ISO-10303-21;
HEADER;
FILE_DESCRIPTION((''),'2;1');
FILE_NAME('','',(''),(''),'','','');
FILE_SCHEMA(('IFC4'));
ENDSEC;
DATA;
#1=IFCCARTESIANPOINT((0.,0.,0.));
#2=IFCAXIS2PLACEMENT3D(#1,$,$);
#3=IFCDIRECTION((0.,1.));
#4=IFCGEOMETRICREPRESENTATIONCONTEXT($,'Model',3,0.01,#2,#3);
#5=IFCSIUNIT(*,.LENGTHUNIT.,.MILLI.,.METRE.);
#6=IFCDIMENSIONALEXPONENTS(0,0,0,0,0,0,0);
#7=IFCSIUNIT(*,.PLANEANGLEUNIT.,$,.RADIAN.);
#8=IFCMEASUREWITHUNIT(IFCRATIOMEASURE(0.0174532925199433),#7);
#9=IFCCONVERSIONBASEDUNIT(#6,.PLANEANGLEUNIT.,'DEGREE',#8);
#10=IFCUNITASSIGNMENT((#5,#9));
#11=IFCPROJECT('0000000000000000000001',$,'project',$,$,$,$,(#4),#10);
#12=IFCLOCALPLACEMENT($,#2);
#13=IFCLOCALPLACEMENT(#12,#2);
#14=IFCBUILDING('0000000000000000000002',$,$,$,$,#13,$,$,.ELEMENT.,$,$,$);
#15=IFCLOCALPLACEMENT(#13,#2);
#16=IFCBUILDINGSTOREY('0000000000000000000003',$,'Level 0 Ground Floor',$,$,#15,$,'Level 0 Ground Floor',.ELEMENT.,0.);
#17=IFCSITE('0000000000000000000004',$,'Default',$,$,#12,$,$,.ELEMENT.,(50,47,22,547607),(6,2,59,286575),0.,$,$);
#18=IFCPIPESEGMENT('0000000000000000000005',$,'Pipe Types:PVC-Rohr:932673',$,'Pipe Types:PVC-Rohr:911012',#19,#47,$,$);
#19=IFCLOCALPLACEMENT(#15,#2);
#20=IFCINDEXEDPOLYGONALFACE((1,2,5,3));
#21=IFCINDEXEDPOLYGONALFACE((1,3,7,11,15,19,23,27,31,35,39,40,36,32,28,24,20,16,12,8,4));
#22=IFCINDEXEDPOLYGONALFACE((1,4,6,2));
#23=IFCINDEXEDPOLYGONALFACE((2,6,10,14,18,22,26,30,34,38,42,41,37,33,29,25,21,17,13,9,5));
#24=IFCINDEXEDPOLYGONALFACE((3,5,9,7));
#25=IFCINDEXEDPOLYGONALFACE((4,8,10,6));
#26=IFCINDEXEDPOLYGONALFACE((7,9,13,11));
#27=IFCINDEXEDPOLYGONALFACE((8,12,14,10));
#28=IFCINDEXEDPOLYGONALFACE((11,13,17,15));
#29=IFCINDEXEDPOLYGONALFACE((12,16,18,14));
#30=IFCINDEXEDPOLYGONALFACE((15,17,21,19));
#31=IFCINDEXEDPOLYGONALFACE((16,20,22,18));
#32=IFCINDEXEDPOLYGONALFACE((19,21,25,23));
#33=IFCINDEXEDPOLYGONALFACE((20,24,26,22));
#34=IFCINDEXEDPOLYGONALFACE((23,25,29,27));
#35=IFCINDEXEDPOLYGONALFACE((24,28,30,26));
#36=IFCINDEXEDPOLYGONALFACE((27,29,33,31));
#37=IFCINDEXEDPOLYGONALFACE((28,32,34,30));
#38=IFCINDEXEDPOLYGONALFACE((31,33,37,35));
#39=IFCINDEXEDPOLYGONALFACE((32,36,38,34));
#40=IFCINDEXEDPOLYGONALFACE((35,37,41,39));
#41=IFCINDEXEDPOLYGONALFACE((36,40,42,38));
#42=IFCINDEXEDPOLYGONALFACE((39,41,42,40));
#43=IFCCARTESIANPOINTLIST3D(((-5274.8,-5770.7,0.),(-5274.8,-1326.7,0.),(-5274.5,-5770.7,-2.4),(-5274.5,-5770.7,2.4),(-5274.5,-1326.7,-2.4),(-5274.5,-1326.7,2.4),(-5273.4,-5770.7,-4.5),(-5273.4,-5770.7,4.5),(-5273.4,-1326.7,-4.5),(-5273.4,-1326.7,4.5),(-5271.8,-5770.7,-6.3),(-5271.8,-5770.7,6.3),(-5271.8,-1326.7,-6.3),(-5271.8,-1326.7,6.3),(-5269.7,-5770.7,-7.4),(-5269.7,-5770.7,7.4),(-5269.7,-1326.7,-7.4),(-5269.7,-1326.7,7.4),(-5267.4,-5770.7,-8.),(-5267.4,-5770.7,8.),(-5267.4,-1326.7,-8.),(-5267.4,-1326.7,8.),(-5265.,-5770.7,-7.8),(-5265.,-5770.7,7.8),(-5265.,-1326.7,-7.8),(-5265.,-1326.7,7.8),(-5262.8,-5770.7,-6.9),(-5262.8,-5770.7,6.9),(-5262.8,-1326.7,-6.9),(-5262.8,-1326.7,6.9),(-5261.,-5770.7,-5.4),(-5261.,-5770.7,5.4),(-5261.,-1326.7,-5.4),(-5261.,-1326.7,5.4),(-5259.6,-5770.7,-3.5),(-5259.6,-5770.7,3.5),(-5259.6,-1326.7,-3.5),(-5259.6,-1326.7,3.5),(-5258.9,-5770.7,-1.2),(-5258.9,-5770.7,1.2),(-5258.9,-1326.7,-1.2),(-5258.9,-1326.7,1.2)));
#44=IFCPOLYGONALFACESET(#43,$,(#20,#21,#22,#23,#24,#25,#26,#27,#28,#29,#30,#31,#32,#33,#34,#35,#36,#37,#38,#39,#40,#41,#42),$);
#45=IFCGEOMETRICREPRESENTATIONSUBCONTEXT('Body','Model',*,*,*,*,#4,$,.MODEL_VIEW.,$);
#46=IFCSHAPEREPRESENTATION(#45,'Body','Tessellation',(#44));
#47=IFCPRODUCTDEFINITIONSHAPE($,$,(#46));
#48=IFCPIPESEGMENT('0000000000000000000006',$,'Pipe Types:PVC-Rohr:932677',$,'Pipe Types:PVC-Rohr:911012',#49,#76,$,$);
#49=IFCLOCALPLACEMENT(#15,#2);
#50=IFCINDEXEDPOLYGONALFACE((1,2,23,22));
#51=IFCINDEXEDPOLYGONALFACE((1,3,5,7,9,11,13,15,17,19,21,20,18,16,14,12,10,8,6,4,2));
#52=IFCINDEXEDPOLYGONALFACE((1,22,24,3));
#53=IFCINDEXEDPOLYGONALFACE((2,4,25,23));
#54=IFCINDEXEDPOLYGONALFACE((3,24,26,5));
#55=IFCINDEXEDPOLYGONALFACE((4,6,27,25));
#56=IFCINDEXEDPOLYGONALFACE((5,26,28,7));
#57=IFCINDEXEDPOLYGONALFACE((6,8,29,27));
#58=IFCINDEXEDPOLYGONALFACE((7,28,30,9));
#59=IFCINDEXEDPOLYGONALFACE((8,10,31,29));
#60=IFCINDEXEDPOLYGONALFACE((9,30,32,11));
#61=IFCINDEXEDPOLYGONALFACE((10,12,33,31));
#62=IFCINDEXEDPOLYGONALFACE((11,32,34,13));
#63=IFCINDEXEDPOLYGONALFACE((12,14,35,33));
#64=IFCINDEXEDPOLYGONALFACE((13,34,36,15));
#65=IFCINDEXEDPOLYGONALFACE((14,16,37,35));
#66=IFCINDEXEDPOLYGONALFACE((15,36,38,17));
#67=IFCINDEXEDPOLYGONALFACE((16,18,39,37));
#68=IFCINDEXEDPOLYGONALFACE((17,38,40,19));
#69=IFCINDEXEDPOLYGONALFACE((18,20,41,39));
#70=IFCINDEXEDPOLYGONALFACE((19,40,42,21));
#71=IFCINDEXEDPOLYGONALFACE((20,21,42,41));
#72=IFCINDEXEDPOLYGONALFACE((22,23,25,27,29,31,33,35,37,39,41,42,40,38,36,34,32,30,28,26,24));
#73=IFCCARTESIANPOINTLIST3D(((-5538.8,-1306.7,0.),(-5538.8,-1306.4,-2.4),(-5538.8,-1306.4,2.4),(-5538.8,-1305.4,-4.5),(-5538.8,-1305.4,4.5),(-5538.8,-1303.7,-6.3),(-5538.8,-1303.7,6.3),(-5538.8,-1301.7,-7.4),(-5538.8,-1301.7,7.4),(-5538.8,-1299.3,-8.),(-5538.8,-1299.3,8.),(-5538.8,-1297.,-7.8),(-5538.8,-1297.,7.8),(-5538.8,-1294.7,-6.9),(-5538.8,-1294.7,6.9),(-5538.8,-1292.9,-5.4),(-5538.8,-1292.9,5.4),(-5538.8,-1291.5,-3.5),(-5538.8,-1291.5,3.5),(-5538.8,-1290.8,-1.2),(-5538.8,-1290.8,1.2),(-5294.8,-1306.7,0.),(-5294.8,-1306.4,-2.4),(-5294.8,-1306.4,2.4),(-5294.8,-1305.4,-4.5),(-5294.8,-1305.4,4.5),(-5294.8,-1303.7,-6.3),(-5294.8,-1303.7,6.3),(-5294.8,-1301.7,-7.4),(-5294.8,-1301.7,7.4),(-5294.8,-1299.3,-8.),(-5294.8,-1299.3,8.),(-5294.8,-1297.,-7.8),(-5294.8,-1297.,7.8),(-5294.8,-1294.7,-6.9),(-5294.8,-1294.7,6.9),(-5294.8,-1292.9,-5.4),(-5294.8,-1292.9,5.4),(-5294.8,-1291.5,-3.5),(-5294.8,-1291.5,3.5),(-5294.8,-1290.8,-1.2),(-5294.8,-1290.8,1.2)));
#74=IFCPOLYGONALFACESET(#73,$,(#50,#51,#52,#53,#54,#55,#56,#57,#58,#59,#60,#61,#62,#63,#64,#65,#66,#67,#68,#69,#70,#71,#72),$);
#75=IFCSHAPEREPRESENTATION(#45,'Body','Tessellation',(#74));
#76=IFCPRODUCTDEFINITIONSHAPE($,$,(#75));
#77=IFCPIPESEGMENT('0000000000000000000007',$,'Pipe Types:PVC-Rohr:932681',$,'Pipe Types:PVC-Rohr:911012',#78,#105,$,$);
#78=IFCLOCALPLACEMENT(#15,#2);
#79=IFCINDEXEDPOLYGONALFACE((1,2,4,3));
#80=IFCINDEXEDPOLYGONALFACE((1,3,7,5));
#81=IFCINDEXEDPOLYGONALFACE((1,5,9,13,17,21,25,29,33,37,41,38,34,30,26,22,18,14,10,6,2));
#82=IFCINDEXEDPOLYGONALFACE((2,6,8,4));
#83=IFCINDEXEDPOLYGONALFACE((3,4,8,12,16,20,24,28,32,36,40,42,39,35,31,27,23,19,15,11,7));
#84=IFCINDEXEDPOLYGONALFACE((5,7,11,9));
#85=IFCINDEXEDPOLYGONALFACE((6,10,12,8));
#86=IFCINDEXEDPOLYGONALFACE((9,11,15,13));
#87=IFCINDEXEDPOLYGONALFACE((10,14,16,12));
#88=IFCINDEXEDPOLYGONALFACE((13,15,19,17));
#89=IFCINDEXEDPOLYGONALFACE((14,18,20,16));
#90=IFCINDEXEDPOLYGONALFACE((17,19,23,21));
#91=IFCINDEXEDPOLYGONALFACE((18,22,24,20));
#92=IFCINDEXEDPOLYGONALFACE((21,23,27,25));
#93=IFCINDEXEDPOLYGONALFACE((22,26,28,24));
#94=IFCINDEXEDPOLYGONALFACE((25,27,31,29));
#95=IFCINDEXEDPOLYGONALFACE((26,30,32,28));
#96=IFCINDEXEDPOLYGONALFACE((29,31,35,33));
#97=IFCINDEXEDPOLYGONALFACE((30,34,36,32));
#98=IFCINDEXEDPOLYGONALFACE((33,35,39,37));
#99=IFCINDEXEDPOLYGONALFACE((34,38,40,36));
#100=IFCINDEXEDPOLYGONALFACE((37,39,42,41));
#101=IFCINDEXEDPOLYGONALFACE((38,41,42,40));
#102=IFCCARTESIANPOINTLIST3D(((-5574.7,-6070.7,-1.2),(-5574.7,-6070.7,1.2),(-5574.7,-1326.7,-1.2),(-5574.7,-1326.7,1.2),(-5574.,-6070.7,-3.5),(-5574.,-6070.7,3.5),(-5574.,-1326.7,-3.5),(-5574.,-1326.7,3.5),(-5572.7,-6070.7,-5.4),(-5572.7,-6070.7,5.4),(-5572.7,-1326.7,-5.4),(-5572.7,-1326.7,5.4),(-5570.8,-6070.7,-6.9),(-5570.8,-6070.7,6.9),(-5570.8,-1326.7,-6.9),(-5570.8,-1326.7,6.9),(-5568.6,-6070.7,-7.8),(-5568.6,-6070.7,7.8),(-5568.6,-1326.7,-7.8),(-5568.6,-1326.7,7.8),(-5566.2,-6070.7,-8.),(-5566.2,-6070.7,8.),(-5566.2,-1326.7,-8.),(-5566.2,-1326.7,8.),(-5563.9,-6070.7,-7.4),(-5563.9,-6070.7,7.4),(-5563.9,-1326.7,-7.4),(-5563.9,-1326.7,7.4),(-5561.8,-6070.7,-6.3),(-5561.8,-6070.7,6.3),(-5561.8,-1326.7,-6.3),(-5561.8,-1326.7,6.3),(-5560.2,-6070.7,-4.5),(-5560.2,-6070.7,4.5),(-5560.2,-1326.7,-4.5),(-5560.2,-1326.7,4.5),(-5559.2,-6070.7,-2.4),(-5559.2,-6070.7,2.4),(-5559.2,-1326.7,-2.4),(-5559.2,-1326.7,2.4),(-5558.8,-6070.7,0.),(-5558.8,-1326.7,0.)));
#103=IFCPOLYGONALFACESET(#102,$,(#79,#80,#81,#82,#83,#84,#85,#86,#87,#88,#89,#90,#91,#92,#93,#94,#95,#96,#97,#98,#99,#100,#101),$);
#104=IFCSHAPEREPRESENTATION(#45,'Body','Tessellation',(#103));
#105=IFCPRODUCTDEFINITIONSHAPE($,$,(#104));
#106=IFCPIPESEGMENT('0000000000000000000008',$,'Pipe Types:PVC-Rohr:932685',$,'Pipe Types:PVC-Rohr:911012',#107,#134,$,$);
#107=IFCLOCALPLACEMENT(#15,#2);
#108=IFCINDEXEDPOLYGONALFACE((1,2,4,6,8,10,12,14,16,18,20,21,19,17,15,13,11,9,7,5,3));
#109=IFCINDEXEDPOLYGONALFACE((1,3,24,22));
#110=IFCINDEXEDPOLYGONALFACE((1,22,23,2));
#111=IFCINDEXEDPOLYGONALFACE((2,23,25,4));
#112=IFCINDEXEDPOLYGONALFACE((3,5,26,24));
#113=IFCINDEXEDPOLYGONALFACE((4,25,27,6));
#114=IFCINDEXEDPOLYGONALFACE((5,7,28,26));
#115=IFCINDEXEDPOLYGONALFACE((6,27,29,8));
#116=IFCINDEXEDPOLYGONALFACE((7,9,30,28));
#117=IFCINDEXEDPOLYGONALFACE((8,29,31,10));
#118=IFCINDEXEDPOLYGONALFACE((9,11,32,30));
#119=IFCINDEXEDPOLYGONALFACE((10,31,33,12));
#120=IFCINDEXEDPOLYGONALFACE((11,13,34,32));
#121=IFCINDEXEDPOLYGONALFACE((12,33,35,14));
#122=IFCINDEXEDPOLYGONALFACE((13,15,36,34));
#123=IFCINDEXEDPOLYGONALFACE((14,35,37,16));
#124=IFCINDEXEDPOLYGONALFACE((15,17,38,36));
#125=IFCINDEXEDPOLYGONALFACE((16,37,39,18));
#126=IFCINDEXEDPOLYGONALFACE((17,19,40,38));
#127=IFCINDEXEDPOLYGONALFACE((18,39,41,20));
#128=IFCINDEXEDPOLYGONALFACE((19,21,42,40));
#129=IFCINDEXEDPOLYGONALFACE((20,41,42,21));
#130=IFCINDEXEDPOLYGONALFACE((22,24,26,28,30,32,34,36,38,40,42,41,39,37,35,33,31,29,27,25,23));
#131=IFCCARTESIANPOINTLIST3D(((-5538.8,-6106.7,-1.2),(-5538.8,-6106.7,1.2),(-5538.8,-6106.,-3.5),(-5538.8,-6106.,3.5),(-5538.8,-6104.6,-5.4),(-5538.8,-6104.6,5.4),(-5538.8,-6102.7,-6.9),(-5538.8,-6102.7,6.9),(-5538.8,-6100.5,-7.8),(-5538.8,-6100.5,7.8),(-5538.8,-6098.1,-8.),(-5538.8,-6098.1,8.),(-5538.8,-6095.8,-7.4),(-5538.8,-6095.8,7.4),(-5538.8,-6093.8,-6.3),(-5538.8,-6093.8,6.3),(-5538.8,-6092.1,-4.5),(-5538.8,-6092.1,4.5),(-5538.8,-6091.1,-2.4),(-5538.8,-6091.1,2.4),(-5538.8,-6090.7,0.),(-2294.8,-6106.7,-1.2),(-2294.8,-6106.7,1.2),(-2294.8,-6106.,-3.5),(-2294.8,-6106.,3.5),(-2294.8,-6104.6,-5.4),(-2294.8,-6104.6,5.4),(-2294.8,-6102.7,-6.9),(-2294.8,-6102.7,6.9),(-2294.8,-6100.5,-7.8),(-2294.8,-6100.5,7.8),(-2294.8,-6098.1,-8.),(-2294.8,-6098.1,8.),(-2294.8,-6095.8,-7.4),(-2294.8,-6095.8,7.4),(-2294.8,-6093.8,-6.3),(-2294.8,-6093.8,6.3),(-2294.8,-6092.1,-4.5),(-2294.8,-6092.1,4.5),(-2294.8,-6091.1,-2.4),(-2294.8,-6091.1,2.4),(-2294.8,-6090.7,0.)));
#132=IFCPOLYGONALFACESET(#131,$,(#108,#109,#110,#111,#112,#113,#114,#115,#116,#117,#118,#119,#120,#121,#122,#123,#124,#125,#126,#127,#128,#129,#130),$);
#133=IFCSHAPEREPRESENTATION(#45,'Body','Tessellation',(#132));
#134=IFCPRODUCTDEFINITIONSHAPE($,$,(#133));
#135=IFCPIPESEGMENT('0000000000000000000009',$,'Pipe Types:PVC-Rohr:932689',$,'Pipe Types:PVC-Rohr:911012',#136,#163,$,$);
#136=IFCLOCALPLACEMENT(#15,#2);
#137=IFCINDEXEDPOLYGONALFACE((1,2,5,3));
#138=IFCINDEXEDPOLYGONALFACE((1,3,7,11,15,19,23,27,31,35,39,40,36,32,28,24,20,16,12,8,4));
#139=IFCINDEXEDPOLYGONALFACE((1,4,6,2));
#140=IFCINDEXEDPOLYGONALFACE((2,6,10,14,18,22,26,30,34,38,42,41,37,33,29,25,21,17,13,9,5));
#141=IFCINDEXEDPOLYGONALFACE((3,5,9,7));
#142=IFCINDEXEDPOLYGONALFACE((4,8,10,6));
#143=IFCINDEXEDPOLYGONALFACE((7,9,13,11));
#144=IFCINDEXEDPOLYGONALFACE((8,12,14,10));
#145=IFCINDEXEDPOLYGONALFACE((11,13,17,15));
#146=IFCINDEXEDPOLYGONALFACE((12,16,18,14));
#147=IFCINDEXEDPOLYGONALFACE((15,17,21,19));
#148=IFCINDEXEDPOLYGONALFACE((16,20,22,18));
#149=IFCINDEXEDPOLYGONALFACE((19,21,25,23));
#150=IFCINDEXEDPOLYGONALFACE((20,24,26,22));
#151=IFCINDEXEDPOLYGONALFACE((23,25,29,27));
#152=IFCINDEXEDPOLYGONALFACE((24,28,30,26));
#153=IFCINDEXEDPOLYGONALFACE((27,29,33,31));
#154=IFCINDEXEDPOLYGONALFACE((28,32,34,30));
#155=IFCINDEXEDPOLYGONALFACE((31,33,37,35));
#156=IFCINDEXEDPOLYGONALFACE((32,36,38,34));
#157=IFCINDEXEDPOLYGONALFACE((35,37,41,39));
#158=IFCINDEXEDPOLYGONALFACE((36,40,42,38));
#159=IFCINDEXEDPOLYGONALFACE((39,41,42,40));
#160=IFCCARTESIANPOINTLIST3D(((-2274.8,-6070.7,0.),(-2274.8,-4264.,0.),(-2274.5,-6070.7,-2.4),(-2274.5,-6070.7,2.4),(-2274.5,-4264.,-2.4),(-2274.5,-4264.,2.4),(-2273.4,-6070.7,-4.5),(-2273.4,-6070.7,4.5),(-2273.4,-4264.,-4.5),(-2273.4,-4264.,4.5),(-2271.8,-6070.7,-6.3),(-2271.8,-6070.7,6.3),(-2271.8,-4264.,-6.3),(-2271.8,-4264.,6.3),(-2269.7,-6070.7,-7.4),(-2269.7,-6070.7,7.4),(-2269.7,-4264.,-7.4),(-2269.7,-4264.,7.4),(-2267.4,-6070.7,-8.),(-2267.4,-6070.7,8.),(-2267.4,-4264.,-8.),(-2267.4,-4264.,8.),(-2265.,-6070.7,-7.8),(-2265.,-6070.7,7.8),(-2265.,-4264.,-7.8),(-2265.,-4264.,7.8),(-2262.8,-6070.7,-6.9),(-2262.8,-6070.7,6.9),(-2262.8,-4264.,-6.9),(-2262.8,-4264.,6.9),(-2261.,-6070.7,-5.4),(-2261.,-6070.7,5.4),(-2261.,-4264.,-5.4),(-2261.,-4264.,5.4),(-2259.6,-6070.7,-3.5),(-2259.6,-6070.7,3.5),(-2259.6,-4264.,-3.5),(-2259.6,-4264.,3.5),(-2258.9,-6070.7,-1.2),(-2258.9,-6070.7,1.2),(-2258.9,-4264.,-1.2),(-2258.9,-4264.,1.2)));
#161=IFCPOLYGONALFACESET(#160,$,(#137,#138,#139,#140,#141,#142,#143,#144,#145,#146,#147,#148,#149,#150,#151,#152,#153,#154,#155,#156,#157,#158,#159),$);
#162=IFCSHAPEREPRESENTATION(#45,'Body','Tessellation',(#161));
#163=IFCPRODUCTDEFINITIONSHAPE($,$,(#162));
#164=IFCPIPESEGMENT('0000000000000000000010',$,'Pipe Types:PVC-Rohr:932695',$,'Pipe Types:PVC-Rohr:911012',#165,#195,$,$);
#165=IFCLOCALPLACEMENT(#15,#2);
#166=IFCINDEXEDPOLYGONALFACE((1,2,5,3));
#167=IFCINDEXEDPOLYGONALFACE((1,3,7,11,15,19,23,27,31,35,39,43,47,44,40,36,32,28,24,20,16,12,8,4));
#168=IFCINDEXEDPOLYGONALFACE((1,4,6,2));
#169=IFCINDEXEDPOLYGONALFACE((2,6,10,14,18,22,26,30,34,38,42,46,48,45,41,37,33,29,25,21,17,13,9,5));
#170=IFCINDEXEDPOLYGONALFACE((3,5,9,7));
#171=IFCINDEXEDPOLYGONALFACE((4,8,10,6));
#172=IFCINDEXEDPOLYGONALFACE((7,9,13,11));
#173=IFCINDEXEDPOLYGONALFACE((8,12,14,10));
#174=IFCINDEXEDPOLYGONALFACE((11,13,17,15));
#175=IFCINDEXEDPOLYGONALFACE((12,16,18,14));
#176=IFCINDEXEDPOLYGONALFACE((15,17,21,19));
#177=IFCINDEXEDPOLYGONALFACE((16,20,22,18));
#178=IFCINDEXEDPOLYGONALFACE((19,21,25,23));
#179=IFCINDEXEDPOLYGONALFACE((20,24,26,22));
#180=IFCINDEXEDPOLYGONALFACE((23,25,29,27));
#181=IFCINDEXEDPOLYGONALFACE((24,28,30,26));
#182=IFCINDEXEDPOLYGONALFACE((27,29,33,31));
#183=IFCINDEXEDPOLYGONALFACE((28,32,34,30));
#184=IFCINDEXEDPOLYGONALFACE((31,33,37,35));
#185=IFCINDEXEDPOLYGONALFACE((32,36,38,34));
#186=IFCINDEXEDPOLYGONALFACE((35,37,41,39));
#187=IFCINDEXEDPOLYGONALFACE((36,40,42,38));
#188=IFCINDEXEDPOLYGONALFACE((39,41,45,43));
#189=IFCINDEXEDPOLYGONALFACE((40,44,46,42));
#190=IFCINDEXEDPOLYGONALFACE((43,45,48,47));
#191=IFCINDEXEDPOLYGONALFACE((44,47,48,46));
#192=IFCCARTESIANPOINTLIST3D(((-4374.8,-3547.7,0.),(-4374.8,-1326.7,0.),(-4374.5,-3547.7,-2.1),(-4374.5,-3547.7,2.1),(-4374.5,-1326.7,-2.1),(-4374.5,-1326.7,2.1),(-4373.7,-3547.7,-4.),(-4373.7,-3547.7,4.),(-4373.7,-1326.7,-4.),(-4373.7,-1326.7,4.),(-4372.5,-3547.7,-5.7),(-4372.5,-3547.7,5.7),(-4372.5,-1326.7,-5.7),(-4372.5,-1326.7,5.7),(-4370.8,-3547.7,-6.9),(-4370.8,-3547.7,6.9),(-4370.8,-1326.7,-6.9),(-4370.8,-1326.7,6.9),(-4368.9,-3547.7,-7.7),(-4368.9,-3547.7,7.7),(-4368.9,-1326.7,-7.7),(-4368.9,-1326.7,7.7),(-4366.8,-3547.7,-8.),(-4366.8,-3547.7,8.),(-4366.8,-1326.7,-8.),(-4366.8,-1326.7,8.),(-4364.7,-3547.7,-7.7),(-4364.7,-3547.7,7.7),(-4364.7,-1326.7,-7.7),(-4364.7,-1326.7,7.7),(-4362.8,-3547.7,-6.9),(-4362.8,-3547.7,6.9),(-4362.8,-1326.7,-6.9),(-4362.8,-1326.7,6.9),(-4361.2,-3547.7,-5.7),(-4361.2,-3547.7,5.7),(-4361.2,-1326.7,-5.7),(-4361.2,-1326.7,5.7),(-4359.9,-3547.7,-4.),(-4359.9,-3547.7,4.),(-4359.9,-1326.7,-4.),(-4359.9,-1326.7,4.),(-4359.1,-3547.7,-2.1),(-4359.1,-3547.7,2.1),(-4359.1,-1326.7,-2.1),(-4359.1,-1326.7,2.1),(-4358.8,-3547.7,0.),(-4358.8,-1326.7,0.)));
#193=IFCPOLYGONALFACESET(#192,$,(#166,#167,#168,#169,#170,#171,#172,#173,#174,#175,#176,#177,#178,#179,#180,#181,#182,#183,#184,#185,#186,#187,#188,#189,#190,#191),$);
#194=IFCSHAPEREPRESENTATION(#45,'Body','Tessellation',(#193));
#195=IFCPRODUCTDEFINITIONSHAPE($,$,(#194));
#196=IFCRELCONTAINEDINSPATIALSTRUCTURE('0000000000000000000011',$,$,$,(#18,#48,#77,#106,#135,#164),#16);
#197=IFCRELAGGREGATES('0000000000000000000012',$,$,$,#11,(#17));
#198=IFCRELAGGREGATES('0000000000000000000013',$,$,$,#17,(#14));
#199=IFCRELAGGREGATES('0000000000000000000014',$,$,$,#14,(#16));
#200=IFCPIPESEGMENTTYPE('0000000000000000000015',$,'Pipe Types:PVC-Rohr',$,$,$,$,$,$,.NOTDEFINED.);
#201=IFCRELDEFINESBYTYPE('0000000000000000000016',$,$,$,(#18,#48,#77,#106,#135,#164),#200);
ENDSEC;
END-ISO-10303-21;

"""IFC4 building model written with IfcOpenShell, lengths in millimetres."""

from ifc_helpers import new_model, entity, si_unit, converted_unit, direction, frame, frame_2d, origin, place, context, subcontext, project, spatial, polyline, circle, outline, extrude, type_object, element, save


model = new_model("IFC4")

# Units and contexts
model_context = context("Model", 3, precision=0.01, world=origin(), true_north=direction((0.0, 1.0)))
body_context = subcontext(model_context, "Body", "Model", "MODEL_VIEW")
ifc_project = project(units=[si_unit("LENGTHUNIT", "METRE", prefix="MILLI"), converted_unit("PLANEANGLEUNIT", "DEGREE", entity("IfcRatioMeasure", 0.0174532925199433), si_unit("PLANEANGLEUNIT", "RADIAN"), dimensions=[0, 0, 0, 0, 0, 0, 0])], contexts=[model_context])

# Site, building, storey
site_placement = place(None, origin())
site = spatial("IfcSite", under=ifc_project, at=site_placement, Name="Default", CompositionType="ELEMENT", RefLatitude=(50, 47, 22, 547607), RefLongitude=(6, 2, 59, 286575), RefElevation=0.0)
building_placement = place(site_placement, origin())
building = spatial("IfcBuilding", under=site, at=building_placement, CompositionType="ELEMENT")
storey_placement = place(building_placement, origin())
storey = spatial("IfcBuildingStorey", under=building, at=storey_placement, Name="Level 0 Ground Floor", LongName="Level 0 Ground Floor", CompositionType="ELEMENT", Elevation=0.0)

# Pipe segments
pipe_segment_type = type_object("IfcPipeSegmentType", Name="Pipe Types:PVC-Rohr", PredefinedType="NOTDEFINED")
pipe_segment_1_placement = place(storey_placement, frame((-5276.4, -5770.7, -9.6)))
element("IfcPipeSegment", 1, at=pipe_segment_1_placement, inside=storey, type_object=pipe_segment_type, Name="Pipe Types:PVC-Rohr:932673", ObjectType="Pipe Types:PVC-Rohr:911012", context=body_context, shape_type="SweptSolid", body=[
    extrude(circle(Radius=8.0, at=frame_2d((0.0, 0.0), x_axis=(1.0, 0.0))), frame((9.6, 0.0, 9.6), z_axis=(0.0, 1.0, 0.0), x_axis=(-1.0, 0.0, 0.0)), (0.0, 0.0, 1.0), 4444.0),
])
pipe_segment_2_placement = place(storey_placement, frame((-5538.8, -1308.3, -9.6)))
element("IfcPipeSegment", 2, at=pipe_segment_2_placement, inside=storey, type_object=pipe_segment_type, Name="Pipe Types:PVC-Rohr:932677", ObjectType="Pipe Types:PVC-Rohr:911012", context=body_context, shape_type="SweptSolid", body=[
    extrude(circle(Radius=8.0, at=frame_2d((0.0, 0.0), x_axis=(1.0, 0.0))), frame((0.0, 9.6, 9.6), z_axis=(1.0, 0.0, 0.0), x_axis=(0.0, -1.0, 0.0)), (0.0, 0.0, 1.0), 244.0),
])
pipe_segment_3_placement = place(storey_placement, frame((-5576.4, -6070.7, -9.6)))
element("IfcPipeSegment", 3, at=pipe_segment_3_placement, inside=storey, type_object=pipe_segment_type, Name="Pipe Types:PVC-Rohr:932681", ObjectType="Pipe Types:PVC-Rohr:911012", context=body_context, shape_type="SweptSolid", body=[
    extrude(circle(Radius=8.0, at=frame_2d((0.0, 0.0), x_axis=(1.0, 0.0))), frame((9.6, 0.0, 9.6), z_axis=(0.0, 1.0, 0.0), x_axis=(1.0, 0.0, 0.0)), (0.0, 0.0, 1.0), 4744.0),
])
pipe_segment_4_placement = place(storey_placement, frame((-5538.8, -6108.3, -9.6)))
element("IfcPipeSegment", 4, at=pipe_segment_4_placement, inside=storey, type_object=pipe_segment_type, Name="Pipe Types:PVC-Rohr:932685", ObjectType="Pipe Types:PVC-Rohr:911012", context=body_context, shape_type="SweptSolid", body=[
    extrude(circle(Radius=8.0, at=frame_2d((0.0, 0.0), x_axis=(1.0, 0.0))), frame((0.0, 9.6, 9.6), z_axis=(1.0, 0.0, 0.0), x_axis=(0.0, 1.0, 0.0)), (0.0, 0.0, 1.0), 3244.0),
])
pipe_segment_5_placement = place(storey_placement, frame((-2276.4, -6070.7, -9.6)))
element("IfcPipeSegment", 5, at=pipe_segment_5_placement, inside=storey, type_object=pipe_segment_type, Name="Pipe Types:PVC-Rohr:932689", ObjectType="Pipe Types:PVC-Rohr:911012", context=body_context, shape_type="SweptSolid", body=[
    extrude(circle(Radius=8.0, at=frame_2d((0.0, 0.0), x_axis=(1.0, 0.0))), frame((9.6, 0.0, 9.6), z_axis=(0.0, 1.0, 0.0), x_axis=(-1.0, 0.0, 0.0)), (0.0, 0.0, 1.0), 1806.7),
])
pipe_segment_6_placement = place(storey_placement, frame((-4376.4, -3547.7, -9.6)))
element("IfcPipeSegment", 6, at=pipe_segment_6_placement, inside=storey, type_object=pipe_segment_type, Name="Pipe Types:PVC-Rohr:932695", ObjectType="Pipe Types:PVC-Rohr:911012", context=body_context, shape_type="SweptSolid", body=[
    extrude(outline(polyline([(-1.0, -7.9), (1.0, -7.9), (3.1, -7.4), (4.9, -6.3), (6.3, -4.9), (7.4, -3.1), (7.9, -1.0), (7.9, 1.0), (7.4, 3.1), (6.3, 4.9), (4.9, 6.3), (3.1, 7.4), (1.0, 7.9), (-1.0, 7.9), (-3.1, 7.4), (-4.9, 6.3), (-6.3, 4.9), (-7.4, 3.1), (-7.9, 1.0), (-7.9, -1.0), (-7.4, -3.1), (-6.3, -4.9), (-4.9, -6.3), (-3.1, -7.4), (-1.0, -7.9)])), frame((9.6, 0.0, 9.6), z_axis=(0.0, 1.0, 0.0), x_axis=(0.130526, 0.0, 0.991445)), (0.0, 0.0, 1.0), 2221.0),
])

save(model, "model.ifc")
